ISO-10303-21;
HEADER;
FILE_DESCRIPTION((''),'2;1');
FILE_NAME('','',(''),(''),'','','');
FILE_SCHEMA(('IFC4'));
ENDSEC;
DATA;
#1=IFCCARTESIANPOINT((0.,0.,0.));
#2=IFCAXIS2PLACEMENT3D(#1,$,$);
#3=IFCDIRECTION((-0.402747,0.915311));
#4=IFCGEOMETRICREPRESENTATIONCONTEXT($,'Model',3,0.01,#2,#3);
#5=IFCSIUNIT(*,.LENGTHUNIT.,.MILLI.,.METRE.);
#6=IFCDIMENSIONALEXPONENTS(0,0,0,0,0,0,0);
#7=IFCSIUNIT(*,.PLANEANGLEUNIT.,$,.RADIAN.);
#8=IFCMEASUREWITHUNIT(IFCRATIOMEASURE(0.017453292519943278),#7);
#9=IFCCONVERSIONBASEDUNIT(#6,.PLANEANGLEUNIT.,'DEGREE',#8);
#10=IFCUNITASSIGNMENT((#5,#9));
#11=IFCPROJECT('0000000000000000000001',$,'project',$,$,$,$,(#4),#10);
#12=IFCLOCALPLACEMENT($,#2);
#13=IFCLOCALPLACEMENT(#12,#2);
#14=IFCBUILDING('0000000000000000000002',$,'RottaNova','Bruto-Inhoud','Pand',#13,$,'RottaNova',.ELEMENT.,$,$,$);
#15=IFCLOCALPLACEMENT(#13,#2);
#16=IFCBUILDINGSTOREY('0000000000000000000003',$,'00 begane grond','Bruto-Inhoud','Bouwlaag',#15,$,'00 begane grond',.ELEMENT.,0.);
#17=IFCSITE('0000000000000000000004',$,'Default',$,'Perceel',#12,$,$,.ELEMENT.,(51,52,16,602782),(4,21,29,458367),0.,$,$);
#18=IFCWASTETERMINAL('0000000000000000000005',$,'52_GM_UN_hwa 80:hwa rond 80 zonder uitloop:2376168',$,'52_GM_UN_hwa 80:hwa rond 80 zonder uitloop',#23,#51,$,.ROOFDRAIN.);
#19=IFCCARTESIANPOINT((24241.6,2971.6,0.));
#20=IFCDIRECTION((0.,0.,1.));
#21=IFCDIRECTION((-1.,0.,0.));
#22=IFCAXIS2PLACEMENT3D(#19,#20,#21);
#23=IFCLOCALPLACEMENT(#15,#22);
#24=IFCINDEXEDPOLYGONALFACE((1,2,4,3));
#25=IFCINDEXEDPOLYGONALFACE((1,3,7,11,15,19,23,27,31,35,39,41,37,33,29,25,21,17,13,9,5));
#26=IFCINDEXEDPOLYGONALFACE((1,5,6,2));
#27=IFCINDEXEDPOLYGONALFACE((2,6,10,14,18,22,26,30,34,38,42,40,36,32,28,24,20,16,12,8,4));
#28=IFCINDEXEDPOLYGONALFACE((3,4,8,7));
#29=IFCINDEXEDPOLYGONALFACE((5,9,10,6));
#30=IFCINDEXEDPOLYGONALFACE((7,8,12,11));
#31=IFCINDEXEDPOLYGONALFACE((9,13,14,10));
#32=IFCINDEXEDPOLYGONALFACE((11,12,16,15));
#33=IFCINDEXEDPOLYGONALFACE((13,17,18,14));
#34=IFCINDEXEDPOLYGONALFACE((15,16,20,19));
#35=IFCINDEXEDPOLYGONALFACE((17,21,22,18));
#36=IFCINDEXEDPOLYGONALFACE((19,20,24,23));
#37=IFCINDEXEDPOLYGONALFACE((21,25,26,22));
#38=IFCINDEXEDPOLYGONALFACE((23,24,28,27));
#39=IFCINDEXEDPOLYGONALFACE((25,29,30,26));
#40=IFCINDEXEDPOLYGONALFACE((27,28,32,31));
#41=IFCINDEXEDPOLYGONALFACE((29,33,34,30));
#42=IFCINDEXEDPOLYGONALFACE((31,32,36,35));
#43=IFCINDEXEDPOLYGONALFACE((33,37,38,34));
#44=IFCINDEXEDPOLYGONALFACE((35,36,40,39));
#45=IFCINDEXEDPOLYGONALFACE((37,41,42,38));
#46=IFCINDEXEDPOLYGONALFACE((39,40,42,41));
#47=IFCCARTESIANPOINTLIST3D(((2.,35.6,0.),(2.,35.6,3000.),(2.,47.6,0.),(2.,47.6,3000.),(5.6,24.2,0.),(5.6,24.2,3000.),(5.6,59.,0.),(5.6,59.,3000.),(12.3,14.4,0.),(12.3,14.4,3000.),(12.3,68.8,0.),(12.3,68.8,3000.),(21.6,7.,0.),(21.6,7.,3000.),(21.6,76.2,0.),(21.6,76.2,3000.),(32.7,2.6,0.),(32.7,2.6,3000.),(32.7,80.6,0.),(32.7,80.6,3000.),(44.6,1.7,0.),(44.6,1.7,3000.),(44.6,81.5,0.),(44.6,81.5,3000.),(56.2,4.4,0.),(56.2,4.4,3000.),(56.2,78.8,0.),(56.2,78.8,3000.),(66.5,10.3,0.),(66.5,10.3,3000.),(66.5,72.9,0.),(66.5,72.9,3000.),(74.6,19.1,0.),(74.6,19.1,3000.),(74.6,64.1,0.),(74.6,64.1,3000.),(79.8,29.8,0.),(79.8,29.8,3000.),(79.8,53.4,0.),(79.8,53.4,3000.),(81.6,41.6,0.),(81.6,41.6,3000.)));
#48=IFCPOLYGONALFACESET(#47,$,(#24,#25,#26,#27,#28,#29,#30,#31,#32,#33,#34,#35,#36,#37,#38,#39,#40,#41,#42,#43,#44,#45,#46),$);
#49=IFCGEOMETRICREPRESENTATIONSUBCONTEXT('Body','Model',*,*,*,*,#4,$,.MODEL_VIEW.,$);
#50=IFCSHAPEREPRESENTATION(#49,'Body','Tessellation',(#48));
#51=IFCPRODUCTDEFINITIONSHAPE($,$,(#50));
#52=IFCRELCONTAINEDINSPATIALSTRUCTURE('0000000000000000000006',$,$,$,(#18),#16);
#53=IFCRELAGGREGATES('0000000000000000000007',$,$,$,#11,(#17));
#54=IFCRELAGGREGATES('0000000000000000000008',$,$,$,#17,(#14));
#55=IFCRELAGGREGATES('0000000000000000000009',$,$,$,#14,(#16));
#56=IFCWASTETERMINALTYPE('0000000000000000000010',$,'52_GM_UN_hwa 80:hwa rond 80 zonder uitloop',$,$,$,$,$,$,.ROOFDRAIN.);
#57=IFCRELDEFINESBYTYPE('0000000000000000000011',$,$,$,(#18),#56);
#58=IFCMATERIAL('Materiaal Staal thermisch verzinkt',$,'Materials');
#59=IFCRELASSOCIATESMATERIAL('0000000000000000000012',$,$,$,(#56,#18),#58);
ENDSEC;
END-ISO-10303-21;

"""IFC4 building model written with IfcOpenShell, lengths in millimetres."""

from ifc_helpers import new_model, entity, si_unit, converted_unit, direction, frame, frame_2d, origin, place, context, subcontext, project, spatial, circle, extrude, source, transform, mapped, material, type_object, type_shapes, element, save


model = new_model("IFC4")

# Units and contexts
model_context = context("Model", 3, precision=0.01, world=origin(), true_north=direction((-0.402747, 0.915311)))
body_context = subcontext(model_context, "Body", "Model", "MODEL_VIEW")
ifc_project = project(units=[si_unit("LENGTHUNIT", "METRE", prefix="MILLI"), converted_unit("PLANEANGLEUNIT", "DEGREE", entity("IfcRatioMeasure", 0.017453292519943278), si_unit("PLANEANGLEUNIT", "RADIAN"), dimensions=[0, 0, 0, 0, 0, 0, 0])], contexts=[model_context])

# Site, building, storey
site_placement = place(None, origin())
site = spatial("IfcSite", under=ifc_project, at=site_placement, Name="Default", ObjectType="Perceel", CompositionType="ELEMENT", RefLatitude=(51, 52, 16, 602782), RefLongitude=(4, 21, 29, 458367), RefElevation=0.0)
building_placement = place(site_placement, origin())
building = spatial("IfcBuilding", under=site, at=building_placement, Name="RottaNova", Description="Bruto-Inhoud", ObjectType="Pand", LongName="RottaNova", CompositionType="ELEMENT")
storey_placement = place(building_placement, origin())
storey = spatial("IfcBuildingStorey", under=building, at=storey_placement, Name="00 begane grond", Description="Bruto-Inhoud", ObjectType="Bouwlaag", LongName="00 begane grond", CompositionType="ELEMENT", Elevation=0.0)

# Waste terminal
ifc_material_1 = material(Name="Materiaal Staal thermisch verzinkt", Category="Materials")
waste_terminal_type = type_object("IfcWasteTerminalType", Name="52_GM_UN_hwa 80:hwa rond 80 zonder uitloop", PredefinedType="ROOFDRAIN", material=ifc_material_1)
shared_shape_1 = source(origin(), body_context, "Body", "SweptSolid", [
    extrude(circle(Radius=40.0, at=frame_2d((0.0, 0.0), x_axis=(1.0, 0.0))), frame((41.6, 41.6, 0.0)), (0.0, 0.0, 1.0), 3000.0),
])
type_shapes(waste_terminal_type, [shared_shape_1])
waste_terminal_placement = place(storey_placement, frame((24241.6, 2971.6, 0.0), z_axis=(0.0, 0.0, 1.0), x_axis=(-1.0, 0.0, 0.0)))
element("IfcWasteTerminal", 1, at=waste_terminal_placement, inside=storey, type_object=waste_terminal_type, material=ifc_material_1, Name="52_GM_UN_hwa 80:hwa rond 80 zonder uitloop:2376168", ObjectType="52_GM_UN_hwa 80:hwa rond 80 zonder uitloop", PredefinedType="ROOFDRAIN", context=body_context, shape_type="MappedRepresentation", body=[
    mapped(shared_shape_1, transform((0.0, 0.0, 0.0), scale=1.0)),
])

save(model, "model.ifc")
